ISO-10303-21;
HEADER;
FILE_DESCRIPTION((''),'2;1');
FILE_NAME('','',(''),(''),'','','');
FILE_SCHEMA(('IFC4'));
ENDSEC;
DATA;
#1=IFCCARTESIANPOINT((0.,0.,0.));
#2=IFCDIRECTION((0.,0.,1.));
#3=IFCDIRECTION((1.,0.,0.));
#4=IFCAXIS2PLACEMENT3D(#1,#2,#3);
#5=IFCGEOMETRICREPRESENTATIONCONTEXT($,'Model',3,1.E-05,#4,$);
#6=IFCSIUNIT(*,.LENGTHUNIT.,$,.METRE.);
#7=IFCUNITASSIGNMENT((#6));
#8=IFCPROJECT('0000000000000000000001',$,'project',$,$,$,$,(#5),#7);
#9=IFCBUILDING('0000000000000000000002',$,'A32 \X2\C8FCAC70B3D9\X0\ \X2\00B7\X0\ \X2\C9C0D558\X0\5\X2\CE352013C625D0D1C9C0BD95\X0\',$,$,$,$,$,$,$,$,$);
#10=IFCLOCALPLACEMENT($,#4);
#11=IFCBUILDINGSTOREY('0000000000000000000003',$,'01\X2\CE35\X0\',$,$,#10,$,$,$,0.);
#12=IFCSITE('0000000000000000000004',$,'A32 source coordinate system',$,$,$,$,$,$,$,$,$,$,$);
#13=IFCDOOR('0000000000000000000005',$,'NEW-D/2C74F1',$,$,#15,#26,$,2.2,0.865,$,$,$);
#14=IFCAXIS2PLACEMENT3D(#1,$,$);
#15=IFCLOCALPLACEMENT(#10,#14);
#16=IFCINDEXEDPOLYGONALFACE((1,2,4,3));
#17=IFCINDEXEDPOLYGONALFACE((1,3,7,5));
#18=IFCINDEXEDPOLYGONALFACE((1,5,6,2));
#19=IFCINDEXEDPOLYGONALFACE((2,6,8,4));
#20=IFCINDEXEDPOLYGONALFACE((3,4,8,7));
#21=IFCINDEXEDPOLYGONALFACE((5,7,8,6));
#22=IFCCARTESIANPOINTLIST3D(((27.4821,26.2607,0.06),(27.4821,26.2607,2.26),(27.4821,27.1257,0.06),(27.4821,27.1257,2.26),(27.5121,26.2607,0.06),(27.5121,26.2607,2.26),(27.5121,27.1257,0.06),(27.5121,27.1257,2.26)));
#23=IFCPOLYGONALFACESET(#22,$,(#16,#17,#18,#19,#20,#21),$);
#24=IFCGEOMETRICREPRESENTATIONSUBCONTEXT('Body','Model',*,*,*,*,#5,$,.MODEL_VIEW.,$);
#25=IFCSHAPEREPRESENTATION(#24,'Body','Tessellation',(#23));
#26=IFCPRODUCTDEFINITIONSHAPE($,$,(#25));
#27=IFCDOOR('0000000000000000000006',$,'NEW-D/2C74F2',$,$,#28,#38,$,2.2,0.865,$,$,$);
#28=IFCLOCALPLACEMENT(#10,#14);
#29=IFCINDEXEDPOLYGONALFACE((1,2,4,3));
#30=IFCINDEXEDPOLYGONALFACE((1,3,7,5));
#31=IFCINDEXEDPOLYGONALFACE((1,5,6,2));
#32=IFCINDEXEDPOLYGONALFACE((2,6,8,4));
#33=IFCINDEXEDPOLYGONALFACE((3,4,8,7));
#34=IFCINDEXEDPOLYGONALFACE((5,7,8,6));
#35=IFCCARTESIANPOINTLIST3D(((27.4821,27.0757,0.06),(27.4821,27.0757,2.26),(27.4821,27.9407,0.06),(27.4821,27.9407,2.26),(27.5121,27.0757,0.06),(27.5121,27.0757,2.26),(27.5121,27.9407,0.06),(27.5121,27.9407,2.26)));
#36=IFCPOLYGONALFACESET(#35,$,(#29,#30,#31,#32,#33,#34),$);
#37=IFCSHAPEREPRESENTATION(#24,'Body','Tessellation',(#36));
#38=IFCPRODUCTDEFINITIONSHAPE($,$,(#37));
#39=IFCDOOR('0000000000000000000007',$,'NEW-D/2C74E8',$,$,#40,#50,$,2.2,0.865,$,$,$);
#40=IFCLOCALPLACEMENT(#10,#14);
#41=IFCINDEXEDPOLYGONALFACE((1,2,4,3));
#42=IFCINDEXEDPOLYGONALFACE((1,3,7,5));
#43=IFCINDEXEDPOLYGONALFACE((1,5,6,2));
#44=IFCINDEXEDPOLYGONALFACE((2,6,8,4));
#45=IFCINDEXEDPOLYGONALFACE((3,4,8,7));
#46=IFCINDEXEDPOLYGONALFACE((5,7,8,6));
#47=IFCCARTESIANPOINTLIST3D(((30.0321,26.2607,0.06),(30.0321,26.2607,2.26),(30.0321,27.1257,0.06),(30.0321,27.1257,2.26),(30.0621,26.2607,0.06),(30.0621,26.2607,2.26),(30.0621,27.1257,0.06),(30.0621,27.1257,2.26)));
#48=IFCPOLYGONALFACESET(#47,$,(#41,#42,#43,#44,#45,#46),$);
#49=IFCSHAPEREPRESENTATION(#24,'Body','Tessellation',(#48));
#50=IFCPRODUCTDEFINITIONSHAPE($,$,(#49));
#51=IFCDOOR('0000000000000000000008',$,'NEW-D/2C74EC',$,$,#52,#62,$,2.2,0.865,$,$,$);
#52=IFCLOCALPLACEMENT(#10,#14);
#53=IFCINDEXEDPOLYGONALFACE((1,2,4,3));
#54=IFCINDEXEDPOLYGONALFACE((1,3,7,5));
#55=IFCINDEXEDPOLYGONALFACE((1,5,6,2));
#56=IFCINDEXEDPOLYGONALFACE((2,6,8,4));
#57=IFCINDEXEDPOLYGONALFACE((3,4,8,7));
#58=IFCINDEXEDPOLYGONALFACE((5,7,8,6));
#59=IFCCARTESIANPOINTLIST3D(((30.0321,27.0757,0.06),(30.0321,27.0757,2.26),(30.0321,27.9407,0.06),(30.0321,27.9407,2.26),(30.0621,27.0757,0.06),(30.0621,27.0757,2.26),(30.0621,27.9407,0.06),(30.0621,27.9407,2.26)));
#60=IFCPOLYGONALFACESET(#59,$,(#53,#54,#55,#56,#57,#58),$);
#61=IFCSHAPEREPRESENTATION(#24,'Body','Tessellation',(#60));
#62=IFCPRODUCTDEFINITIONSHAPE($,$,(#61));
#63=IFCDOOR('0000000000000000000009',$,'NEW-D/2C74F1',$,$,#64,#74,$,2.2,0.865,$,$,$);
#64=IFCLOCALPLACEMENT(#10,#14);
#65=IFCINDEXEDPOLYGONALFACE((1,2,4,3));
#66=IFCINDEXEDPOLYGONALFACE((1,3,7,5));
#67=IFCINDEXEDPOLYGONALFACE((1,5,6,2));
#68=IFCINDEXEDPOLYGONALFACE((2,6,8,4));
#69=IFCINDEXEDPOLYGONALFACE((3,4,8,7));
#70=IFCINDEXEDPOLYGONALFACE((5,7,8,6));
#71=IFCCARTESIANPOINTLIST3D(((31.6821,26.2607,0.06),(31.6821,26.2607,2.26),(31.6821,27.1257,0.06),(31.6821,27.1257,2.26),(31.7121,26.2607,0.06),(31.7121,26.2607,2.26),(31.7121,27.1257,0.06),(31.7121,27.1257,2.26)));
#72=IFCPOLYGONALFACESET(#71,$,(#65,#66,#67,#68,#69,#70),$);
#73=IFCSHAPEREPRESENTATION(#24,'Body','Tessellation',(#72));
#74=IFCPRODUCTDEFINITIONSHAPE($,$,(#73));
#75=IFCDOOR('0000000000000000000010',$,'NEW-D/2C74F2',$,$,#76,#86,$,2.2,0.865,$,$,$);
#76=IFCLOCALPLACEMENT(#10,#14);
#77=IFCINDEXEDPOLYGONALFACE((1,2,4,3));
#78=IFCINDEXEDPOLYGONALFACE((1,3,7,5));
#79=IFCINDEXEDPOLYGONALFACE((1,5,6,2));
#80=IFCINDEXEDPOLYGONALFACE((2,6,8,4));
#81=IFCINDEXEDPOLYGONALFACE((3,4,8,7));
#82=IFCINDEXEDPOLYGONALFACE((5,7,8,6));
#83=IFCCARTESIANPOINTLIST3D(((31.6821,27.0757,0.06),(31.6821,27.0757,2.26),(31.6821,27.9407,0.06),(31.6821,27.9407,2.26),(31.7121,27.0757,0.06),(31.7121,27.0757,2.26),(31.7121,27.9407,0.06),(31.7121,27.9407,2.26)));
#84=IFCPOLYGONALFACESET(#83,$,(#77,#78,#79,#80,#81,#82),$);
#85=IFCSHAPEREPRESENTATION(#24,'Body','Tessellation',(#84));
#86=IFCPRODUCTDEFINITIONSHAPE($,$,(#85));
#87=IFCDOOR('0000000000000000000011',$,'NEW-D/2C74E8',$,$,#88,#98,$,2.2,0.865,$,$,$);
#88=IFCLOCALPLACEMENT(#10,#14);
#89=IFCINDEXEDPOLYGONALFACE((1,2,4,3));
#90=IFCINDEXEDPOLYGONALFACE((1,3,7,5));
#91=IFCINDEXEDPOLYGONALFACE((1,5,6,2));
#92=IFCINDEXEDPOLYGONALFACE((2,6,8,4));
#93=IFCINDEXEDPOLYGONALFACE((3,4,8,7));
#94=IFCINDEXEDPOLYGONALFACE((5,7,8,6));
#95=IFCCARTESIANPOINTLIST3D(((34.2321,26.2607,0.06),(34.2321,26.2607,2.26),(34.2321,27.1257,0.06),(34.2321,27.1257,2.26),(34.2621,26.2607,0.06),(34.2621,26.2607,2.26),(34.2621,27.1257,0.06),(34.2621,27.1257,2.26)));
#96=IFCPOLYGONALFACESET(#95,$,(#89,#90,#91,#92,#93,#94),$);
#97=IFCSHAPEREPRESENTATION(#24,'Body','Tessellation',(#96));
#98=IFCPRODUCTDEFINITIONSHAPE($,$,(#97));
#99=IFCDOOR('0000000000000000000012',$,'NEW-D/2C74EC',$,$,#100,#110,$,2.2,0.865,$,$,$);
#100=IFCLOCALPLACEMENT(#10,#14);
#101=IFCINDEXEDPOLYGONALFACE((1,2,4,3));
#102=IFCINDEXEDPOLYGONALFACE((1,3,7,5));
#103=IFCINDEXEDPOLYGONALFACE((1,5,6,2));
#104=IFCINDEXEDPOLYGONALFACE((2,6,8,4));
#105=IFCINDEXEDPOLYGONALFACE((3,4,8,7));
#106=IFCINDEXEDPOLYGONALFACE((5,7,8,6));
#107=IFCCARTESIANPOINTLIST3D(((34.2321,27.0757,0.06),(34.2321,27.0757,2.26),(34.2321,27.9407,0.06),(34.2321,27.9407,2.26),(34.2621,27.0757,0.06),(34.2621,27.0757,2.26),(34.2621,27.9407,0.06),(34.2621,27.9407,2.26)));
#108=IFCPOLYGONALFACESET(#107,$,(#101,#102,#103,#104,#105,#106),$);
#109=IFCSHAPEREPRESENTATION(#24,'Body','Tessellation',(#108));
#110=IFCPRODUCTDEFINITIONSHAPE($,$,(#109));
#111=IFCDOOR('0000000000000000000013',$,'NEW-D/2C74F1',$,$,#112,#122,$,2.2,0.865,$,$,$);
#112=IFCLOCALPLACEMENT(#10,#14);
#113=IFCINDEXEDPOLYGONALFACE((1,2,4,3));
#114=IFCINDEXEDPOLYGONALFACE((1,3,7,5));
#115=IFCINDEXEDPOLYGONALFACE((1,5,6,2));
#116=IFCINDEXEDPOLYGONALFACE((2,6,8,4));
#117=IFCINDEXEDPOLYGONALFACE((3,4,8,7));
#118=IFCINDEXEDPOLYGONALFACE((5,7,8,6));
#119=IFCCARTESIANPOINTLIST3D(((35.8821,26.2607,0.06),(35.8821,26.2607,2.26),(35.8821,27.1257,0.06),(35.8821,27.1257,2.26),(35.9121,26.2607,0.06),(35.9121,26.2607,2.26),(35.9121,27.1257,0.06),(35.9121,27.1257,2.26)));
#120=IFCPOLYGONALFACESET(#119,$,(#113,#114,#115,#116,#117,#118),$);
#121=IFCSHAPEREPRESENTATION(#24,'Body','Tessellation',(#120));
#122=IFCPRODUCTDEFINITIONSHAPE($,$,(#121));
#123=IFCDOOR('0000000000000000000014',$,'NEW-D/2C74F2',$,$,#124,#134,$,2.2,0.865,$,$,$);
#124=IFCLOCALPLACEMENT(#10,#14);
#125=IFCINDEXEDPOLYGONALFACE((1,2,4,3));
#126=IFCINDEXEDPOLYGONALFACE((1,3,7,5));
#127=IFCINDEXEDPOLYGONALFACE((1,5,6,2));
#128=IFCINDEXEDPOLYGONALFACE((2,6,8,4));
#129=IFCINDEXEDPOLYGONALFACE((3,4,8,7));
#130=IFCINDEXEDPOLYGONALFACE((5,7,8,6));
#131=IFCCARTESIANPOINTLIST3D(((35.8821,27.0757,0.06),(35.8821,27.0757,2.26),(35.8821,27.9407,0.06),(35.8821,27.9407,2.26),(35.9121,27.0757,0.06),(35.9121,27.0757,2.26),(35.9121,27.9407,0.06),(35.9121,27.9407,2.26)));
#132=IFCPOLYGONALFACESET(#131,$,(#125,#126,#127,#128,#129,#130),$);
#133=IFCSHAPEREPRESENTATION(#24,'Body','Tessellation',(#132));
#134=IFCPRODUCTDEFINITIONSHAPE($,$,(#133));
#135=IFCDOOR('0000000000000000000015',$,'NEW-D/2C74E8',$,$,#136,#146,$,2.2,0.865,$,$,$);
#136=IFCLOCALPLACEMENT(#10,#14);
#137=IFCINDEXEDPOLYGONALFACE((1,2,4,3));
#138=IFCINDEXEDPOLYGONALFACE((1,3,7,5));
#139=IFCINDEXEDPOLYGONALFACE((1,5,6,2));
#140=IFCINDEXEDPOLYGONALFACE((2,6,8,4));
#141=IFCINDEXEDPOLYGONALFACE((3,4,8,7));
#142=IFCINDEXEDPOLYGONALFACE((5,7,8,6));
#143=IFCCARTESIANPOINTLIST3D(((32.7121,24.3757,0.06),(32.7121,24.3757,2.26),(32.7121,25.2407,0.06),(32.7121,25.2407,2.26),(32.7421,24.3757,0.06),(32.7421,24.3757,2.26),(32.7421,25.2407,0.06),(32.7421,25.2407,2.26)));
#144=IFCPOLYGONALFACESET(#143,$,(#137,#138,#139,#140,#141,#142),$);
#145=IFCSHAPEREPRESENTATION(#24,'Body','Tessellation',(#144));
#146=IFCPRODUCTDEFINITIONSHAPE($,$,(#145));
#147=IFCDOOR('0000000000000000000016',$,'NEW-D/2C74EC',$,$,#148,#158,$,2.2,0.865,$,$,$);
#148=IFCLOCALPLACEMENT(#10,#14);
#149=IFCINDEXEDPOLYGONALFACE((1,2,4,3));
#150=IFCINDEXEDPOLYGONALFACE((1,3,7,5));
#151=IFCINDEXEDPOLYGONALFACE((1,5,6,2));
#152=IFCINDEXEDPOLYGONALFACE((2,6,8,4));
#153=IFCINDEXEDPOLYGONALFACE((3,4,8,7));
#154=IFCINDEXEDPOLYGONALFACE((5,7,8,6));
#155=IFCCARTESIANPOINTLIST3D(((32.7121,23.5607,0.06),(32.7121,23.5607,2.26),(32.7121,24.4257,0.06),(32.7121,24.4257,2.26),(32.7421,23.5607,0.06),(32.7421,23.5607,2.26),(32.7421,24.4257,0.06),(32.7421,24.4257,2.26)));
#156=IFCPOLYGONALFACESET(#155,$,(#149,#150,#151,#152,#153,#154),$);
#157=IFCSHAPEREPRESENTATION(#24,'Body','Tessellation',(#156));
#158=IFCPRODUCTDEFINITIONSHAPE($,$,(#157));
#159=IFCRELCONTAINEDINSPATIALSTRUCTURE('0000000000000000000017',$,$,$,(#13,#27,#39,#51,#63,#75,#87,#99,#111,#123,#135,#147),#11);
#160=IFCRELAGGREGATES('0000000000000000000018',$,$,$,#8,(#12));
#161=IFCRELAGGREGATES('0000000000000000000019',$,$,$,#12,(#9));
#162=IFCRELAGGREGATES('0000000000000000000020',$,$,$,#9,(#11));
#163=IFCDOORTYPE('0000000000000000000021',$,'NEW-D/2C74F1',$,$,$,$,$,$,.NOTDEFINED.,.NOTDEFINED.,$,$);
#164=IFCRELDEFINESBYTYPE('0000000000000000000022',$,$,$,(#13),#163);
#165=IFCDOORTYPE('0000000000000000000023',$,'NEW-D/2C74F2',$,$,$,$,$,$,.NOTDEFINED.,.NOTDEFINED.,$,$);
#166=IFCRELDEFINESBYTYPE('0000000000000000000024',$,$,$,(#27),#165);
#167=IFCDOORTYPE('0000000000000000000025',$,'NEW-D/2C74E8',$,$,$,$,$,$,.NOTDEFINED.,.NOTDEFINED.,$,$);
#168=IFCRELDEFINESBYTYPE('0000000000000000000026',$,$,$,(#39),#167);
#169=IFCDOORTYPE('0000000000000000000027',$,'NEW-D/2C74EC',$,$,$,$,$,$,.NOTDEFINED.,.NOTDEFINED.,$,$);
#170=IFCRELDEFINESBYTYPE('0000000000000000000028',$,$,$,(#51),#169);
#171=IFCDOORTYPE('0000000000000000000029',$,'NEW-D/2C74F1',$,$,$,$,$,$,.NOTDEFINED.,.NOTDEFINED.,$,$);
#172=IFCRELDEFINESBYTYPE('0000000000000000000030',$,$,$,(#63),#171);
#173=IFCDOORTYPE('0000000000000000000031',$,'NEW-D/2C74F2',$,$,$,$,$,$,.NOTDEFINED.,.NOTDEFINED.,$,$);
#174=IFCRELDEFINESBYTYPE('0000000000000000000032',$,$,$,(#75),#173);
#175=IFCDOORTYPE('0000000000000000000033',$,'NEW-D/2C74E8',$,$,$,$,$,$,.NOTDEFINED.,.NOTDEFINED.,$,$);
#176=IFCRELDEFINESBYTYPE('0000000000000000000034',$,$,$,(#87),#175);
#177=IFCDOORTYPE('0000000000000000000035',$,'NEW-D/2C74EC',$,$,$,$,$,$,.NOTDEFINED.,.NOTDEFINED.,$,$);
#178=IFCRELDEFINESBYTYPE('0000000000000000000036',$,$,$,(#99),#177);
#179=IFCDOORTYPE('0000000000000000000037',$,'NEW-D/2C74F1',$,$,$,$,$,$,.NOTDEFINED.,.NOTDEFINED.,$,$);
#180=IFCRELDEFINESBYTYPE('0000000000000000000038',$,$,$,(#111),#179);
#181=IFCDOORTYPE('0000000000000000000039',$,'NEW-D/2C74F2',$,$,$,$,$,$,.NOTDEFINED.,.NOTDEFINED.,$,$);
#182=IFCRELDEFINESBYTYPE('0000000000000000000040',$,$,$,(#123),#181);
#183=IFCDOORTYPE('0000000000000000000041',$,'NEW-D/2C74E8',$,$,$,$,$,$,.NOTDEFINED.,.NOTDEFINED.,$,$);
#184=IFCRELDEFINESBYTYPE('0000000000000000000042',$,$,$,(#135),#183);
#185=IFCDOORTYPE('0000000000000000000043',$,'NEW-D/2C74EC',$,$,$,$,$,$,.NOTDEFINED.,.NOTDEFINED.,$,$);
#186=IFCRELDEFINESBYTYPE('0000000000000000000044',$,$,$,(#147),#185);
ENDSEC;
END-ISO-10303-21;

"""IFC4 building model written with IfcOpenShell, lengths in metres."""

from ifc_helpers import new_model, si_unit, frame, origin, origin_with_axes, place, context, subcontext, project, spatial, polyline, outline, extrude, source, transform, mapped, type_object, type_shapes, element, save


model = new_model("IFC4")

# Units and contexts
model_context = context("Model", 3, precision=1e-05, world=origin_with_axes())
body_context = subcontext(model_context, "Body", "Model", "MODEL_VIEW")
ifc_project = project(units=[si_unit("LENGTHUNIT", "METRE")], contexts=[model_context])

# Site, building, storey
site = spatial("IfcSite", under=ifc_project, Name="A32 source coordinate system")
building = spatial("IfcBuilding", under=site, Name="A32 주거동 · 지하5층–옥탑지붕")
storey_placement = place(None, origin_with_axes())
storey = spatial("IfcBuildingStorey", under=building, at=storey_placement, Name="01층", Elevation=0.0)

# Doors
door_type_1 = type_object("IfcDoorType", Name="NEW-D/2C74F1", OperationType="NOTDEFINED", PredefinedType="NOTDEFINED")
shared_shape_1 = source(origin(), body_context, "Body", "SweptSolid", [
    extrude(outline(polyline([(27.5121, 26.2607), (27.4821, 26.2607), (27.4821, 27.1257), (27.5121, 27.1257), (27.5121, 26.2607)])), frame((0.0, 0.0, 0.06)), (0.0, 0.0, 1.0), 2.2),
])
type_shapes(door_type_1, [shared_shape_1])
door_1_placement = place(storey_placement, origin_with_axes())
element("IfcDoor", 1, at=door_1_placement, inside=storey, type_object=door_type_1, Name="NEW-D/2C74F1", OverallHeight=2.2, OverallWidth=0.865, context=body_context, shape_type="MappedRepresentation", body=[
    mapped(shared_shape_1, transform((0.0, 0.0, 0.0), scale=1.0)),
])
door_type_2 = type_object("IfcDoorType", Name="NEW-D/2C74F2", OperationType="NOTDEFINED", PredefinedType="NOTDEFINED")
shared_shape_2 = source(origin(), body_context, "Body", "SweptSolid", [
    extrude(outline(polyline([(27.4821, 27.0757), (27.4821, 27.9407), (27.5121, 27.9407), (27.5121, 27.0757), (27.4821, 27.0757)])), frame((0.0, 0.0, 0.06)), (0.0, 0.0, 1.0), 2.2),
])
type_shapes(door_type_2, [shared_shape_2])
door_2_placement = place(storey_placement, origin_with_axes())
element("IfcDoor", 2, at=door_2_placement, inside=storey, type_object=door_type_2, Name="NEW-D/2C74F2", OverallHeight=2.2, OverallWidth=0.865, context=body_context, shape_type="MappedRepresentation", body=[
    mapped(shared_shape_2, transform((0.0, 0.0, 0.0), scale=1.0)),
])
door_type_3 = type_object("IfcDoorType", Name="NEW-D/2C74E8", OperationType="NOTDEFINED", PredefinedType="NOTDEFINED")
shared_shape_3 = source(origin(), body_context, "Body", "SweptSolid", [
    extrude(outline(polyline([(30.0621, 27.1257), (30.0621, 26.2607), (30.0321, 26.2607), (30.0321, 27.1257), (30.0621, 27.1257)])), frame((0.0, 0.0, 0.06)), (0.0, 0.0, 1.0), 2.2),
])
type_shapes(door_type_3, [shared_shape_3])
door_3_placement = place(storey_placement, origin_with_axes())
element("IfcDoor", 3, at=door_3_placement, inside=storey, type_object=door_type_3, Name="NEW-D/2C74E8", OverallHeight=2.2, OverallWidth=0.865, context=body_context, shape_type="MappedRepresentation", body=[
    mapped(shared_shape_3, transform((0.0, 0.0, 0.0), scale=1.0)),
])
door_type_4 = type_object("IfcDoorType", Name="NEW-D/2C74EC", OperationType="NOTDEFINED", PredefinedType="NOTDEFINED")
shared_shape_4 = source(origin(), body_context, "Body", "SweptSolid", [
    extrude(outline(polyline([(30.0321, 27.9407), (30.0621, 27.9407), (30.0621, 27.0757), (30.0321, 27.0757), (30.0321, 27.9407)])), frame((0.0, 0.0, 0.06)), (0.0, 0.0, 1.0), 2.2),
])
type_shapes(door_type_4, [shared_shape_4])
door_4_placement = place(storey_placement, origin_with_axes())
element("IfcDoor", 4, at=door_4_placement, inside=storey, type_object=door_type_4, Name="NEW-D/2C74EC", OverallHeight=2.2, OverallWidth=0.865, context=body_context, shape_type="MappedRepresentation", body=[
    mapped(shared_shape_4, transform((0.0, 0.0, 0.0), scale=1.0)),
])
door_type_5 = type_object("IfcDoorType", Name="NEW-D/2C74F1", OperationType="NOTDEFINED", PredefinedType="NOTDEFINED")
shared_shape_5 = source(origin(), body_context, "Body", "SweptSolid", [
    extrude(outline(polyline([(31.7121, 26.2607), (31.6821, 26.2607), (31.6821, 27.1257), (31.7121, 27.1257), (31.7121, 26.2607)])), frame((0.0, 0.0, 0.06)), (0.0, 0.0, 1.0), 2.2),
])
type_shapes(door_type_5, [shared_shape_5])
door_5_placement = place(storey_placement, origin_with_axes())
element("IfcDoor", 5, at=door_5_placement, inside=storey, type_object=door_type_5, Name="NEW-D/2C74F1", OverallHeight=2.2, OverallWidth=0.865, context=body_context, shape_type="MappedRepresentation", body=[
    mapped(shared_shape_5, transform((0.0, 0.0, 0.0), scale=1.0)),
])
door_type_6 = type_object("IfcDoorType", Name="NEW-D/2C74F2", OperationType="NOTDEFINED", PredefinedType="NOTDEFINED")
shared_shape_6 = source(origin(), body_context, "Body", "SweptSolid", [
    extrude(outline(polyline([(31.6821, 27.0757), (31.6821, 27.9407), (31.7121, 27.9407), (31.7121, 27.0757), (31.6821, 27.0757)])), frame((0.0, 0.0, 0.06)), (0.0, 0.0, 1.0), 2.2),
])
type_shapes(door_type_6, [shared_shape_6])
door_6_placement = place(storey_placement, origin_with_axes())
element("IfcDoor", 6, at=door_6_placement, inside=storey, type_object=door_type_6, Name="NEW-D/2C74F2", OverallHeight=2.2, OverallWidth=0.865, context=body_context, shape_type="MappedRepresentation", body=[
    mapped(shared_shape_6, transform((0.0, 0.0, 0.0), scale=1.0)),
])
door_type_7 = type_object("IfcDoorType", Name="NEW-D/2C74E8", OperationType="NOTDEFINED", PredefinedType="NOTDEFINED")
shared_shape_7 = source(origin(), body_context, "Body", "SweptSolid", [
    extrude(outline(polyline([(34.2621, 27.1257), (34.2621, 26.2607), (34.2321, 26.2607), (34.2321, 27.1257), (34.2621, 27.1257)])), frame((0.0, 0.0, 0.06)), (0.0, 0.0, 1.0), 2.2),
])
type_shapes(door_type_7, [shared_shape_7])
door_7_placement = place(storey_placement, origin_with_axes())
element("IfcDoor", 7, at=door_7_placement, inside=storey, type_object=door_type_7, Name="NEW-D/2C74E8", OverallHeight=2.2, OverallWidth=0.865, context=body_context, shape_type="MappedRepresentation", body=[
    mapped(shared_shape_7, transform((0.0, 0.0, 0.0), scale=1.0)),
])
door_type_8 = type_object("IfcDoorType", Name="NEW-D/2C74EC", OperationType="NOTDEFINED", PredefinedType="NOTDEFINED")
shared_shape_8 = source(origin(), body_context, "Body", "SweptSolid", [
    extrude(outline(polyline([(34.2321, 27.9407), (34.2621, 27.9407), (34.2621, 27.0757), (34.2321, 27.0757), (34.2321, 27.9407)])), frame((0.0, 0.0, 0.06)), (0.0, 0.0, 1.0), 2.2),
])
type_shapes(door_type_8, [shared_shape_8])
door_8_placement = place(storey_placement, origin_with_axes())
element("IfcDoor", 8, at=door_8_placement, inside=storey, type_object=door_type_8, Name="NEW-D/2C74EC", OverallHeight=2.2, OverallWidth=0.865, context=body_context, shape_type="MappedRepresentation", body=[
    mapped(shared_shape_8, transform((0.0, 0.0, 0.0), scale=1.0)),
])
door_type_9 = type_object("IfcDoorType", Name="NEW-D/2C74F1", OperationType="NOTDEFINED", PredefinedType="NOTDEFINED")
shared_shape_9 = source(origin(), body_context, "Body", "SweptSolid", [
    extrude(outline(polyline([(35.9121, 26.2607), (35.8821, 26.2607), (35.8821, 27.1257), (35.9121, 27.1257), (35.9121, 26.2607)])), frame((0.0, 0.0, 0.06)), (0.0, 0.0, 1.0), 2.2),
])
type_shapes(door_type_9, [shared_shape_9])
door_9_placement = place(storey_placement, origin_with_axes())
element("IfcDoor", 9, at=door_9_placement, inside=storey, type_object=door_type_9, Name="NEW-D/2C74F1", OverallHeight=2.2, OverallWidth=0.865, context=body_context, shape_type="MappedRepresentation", body=[
    mapped(shared_shape_9, transform((0.0, 0.0, 0.0), scale=1.0)),
])
door_type_10 = type_object("IfcDoorType", Name="NEW-D/2C74F2", OperationType="NOTDEFINED", PredefinedType="NOTDEFINED")
shared_shape_10 = source(origin(), body_context, "Body", "SweptSolid", [
    extrude(outline(polyline([(35.8821, 27.0757), (35.8821, 27.9407), (35.9121, 27.9407), (35.9121, 27.0757), (35.8821, 27.0757)])), frame((0.0, 0.0, 0.06)), (0.0, 0.0, 1.0), 2.2),
])
type_shapes(door_type_10, [shared_shape_10])
door_10_placement = place(storey_placement, origin_with_axes())
element("IfcDoor", 10, at=door_10_placement, inside=storey, type_object=door_type_10, Name="NEW-D/2C74F2", OverallHeight=2.2, OverallWidth=0.865, context=body_context, shape_type="MappedRepresentation", body=[
    mapped(shared_shape_10, transform((0.0, 0.0, 0.0), scale=1.0)),
])
door_type_11 = type_object("IfcDoorType", Name="NEW-D/2C74E8", OperationType="NOTDEFINED", PredefinedType="NOTDEFINED")
shared_shape_11 = source(origin(), body_context, "Body", "SweptSolid", [
    extrude(outline(polyline([(32.7121, 25.2407), (32.7421, 25.2407), (32.7421, 24.3757), (32.7121, 24.3757), (32.7121, 25.2407)])), frame((0.0, 0.0, 0.06)), (0.0, 0.0, 1.0), 2.2),
])
type_shapes(door_type_11, [shared_shape_11])
door_11_placement = place(storey_placement, origin_with_axes())
element("IfcDoor", 11, at=door_11_placement, inside=storey, type_object=door_type_11, Name="NEW-D/2C74E8", OverallHeight=2.2, OverallWidth=0.865, context=body_context, shape_type="MappedRepresentation", body=[
    mapped(shared_shape_11, transform((0.0, 0.0, 0.0), scale=1.0)),
])
door_type_12 = type_object("IfcDoorType", Name="NEW-D/2C74EC", OperationType="NOTDEFINED", PredefinedType="NOTDEFINED")
shared_shape_12 = source(origin(), body_context, "Body", "SweptSolid", [
    extrude(outline(polyline([(32.7421, 24.4257), (32.7421, 23.5607), (32.7121, 23.5607), (32.7121, 24.4257), (32.7421, 24.4257)])), frame((0.0, 0.0, 0.06)), (0.0, 0.0, 1.0), 2.2),
])
type_shapes(door_type_12, [shared_shape_12])
door_12_placement = place(storey_placement, origin_with_axes())
element("IfcDoor", 12, at=door_12_placement, inside=storey, type_object=door_type_12, Name="NEW-D/2C74EC", OverallHeight=2.2, OverallWidth=0.865, context=body_context, shape_type="MappedRepresentation", body=[
    mapped(shared_shape_12, transform((0.0, 0.0, 0.0), scale=1.0)),
])

save(model, "model.ifc")
